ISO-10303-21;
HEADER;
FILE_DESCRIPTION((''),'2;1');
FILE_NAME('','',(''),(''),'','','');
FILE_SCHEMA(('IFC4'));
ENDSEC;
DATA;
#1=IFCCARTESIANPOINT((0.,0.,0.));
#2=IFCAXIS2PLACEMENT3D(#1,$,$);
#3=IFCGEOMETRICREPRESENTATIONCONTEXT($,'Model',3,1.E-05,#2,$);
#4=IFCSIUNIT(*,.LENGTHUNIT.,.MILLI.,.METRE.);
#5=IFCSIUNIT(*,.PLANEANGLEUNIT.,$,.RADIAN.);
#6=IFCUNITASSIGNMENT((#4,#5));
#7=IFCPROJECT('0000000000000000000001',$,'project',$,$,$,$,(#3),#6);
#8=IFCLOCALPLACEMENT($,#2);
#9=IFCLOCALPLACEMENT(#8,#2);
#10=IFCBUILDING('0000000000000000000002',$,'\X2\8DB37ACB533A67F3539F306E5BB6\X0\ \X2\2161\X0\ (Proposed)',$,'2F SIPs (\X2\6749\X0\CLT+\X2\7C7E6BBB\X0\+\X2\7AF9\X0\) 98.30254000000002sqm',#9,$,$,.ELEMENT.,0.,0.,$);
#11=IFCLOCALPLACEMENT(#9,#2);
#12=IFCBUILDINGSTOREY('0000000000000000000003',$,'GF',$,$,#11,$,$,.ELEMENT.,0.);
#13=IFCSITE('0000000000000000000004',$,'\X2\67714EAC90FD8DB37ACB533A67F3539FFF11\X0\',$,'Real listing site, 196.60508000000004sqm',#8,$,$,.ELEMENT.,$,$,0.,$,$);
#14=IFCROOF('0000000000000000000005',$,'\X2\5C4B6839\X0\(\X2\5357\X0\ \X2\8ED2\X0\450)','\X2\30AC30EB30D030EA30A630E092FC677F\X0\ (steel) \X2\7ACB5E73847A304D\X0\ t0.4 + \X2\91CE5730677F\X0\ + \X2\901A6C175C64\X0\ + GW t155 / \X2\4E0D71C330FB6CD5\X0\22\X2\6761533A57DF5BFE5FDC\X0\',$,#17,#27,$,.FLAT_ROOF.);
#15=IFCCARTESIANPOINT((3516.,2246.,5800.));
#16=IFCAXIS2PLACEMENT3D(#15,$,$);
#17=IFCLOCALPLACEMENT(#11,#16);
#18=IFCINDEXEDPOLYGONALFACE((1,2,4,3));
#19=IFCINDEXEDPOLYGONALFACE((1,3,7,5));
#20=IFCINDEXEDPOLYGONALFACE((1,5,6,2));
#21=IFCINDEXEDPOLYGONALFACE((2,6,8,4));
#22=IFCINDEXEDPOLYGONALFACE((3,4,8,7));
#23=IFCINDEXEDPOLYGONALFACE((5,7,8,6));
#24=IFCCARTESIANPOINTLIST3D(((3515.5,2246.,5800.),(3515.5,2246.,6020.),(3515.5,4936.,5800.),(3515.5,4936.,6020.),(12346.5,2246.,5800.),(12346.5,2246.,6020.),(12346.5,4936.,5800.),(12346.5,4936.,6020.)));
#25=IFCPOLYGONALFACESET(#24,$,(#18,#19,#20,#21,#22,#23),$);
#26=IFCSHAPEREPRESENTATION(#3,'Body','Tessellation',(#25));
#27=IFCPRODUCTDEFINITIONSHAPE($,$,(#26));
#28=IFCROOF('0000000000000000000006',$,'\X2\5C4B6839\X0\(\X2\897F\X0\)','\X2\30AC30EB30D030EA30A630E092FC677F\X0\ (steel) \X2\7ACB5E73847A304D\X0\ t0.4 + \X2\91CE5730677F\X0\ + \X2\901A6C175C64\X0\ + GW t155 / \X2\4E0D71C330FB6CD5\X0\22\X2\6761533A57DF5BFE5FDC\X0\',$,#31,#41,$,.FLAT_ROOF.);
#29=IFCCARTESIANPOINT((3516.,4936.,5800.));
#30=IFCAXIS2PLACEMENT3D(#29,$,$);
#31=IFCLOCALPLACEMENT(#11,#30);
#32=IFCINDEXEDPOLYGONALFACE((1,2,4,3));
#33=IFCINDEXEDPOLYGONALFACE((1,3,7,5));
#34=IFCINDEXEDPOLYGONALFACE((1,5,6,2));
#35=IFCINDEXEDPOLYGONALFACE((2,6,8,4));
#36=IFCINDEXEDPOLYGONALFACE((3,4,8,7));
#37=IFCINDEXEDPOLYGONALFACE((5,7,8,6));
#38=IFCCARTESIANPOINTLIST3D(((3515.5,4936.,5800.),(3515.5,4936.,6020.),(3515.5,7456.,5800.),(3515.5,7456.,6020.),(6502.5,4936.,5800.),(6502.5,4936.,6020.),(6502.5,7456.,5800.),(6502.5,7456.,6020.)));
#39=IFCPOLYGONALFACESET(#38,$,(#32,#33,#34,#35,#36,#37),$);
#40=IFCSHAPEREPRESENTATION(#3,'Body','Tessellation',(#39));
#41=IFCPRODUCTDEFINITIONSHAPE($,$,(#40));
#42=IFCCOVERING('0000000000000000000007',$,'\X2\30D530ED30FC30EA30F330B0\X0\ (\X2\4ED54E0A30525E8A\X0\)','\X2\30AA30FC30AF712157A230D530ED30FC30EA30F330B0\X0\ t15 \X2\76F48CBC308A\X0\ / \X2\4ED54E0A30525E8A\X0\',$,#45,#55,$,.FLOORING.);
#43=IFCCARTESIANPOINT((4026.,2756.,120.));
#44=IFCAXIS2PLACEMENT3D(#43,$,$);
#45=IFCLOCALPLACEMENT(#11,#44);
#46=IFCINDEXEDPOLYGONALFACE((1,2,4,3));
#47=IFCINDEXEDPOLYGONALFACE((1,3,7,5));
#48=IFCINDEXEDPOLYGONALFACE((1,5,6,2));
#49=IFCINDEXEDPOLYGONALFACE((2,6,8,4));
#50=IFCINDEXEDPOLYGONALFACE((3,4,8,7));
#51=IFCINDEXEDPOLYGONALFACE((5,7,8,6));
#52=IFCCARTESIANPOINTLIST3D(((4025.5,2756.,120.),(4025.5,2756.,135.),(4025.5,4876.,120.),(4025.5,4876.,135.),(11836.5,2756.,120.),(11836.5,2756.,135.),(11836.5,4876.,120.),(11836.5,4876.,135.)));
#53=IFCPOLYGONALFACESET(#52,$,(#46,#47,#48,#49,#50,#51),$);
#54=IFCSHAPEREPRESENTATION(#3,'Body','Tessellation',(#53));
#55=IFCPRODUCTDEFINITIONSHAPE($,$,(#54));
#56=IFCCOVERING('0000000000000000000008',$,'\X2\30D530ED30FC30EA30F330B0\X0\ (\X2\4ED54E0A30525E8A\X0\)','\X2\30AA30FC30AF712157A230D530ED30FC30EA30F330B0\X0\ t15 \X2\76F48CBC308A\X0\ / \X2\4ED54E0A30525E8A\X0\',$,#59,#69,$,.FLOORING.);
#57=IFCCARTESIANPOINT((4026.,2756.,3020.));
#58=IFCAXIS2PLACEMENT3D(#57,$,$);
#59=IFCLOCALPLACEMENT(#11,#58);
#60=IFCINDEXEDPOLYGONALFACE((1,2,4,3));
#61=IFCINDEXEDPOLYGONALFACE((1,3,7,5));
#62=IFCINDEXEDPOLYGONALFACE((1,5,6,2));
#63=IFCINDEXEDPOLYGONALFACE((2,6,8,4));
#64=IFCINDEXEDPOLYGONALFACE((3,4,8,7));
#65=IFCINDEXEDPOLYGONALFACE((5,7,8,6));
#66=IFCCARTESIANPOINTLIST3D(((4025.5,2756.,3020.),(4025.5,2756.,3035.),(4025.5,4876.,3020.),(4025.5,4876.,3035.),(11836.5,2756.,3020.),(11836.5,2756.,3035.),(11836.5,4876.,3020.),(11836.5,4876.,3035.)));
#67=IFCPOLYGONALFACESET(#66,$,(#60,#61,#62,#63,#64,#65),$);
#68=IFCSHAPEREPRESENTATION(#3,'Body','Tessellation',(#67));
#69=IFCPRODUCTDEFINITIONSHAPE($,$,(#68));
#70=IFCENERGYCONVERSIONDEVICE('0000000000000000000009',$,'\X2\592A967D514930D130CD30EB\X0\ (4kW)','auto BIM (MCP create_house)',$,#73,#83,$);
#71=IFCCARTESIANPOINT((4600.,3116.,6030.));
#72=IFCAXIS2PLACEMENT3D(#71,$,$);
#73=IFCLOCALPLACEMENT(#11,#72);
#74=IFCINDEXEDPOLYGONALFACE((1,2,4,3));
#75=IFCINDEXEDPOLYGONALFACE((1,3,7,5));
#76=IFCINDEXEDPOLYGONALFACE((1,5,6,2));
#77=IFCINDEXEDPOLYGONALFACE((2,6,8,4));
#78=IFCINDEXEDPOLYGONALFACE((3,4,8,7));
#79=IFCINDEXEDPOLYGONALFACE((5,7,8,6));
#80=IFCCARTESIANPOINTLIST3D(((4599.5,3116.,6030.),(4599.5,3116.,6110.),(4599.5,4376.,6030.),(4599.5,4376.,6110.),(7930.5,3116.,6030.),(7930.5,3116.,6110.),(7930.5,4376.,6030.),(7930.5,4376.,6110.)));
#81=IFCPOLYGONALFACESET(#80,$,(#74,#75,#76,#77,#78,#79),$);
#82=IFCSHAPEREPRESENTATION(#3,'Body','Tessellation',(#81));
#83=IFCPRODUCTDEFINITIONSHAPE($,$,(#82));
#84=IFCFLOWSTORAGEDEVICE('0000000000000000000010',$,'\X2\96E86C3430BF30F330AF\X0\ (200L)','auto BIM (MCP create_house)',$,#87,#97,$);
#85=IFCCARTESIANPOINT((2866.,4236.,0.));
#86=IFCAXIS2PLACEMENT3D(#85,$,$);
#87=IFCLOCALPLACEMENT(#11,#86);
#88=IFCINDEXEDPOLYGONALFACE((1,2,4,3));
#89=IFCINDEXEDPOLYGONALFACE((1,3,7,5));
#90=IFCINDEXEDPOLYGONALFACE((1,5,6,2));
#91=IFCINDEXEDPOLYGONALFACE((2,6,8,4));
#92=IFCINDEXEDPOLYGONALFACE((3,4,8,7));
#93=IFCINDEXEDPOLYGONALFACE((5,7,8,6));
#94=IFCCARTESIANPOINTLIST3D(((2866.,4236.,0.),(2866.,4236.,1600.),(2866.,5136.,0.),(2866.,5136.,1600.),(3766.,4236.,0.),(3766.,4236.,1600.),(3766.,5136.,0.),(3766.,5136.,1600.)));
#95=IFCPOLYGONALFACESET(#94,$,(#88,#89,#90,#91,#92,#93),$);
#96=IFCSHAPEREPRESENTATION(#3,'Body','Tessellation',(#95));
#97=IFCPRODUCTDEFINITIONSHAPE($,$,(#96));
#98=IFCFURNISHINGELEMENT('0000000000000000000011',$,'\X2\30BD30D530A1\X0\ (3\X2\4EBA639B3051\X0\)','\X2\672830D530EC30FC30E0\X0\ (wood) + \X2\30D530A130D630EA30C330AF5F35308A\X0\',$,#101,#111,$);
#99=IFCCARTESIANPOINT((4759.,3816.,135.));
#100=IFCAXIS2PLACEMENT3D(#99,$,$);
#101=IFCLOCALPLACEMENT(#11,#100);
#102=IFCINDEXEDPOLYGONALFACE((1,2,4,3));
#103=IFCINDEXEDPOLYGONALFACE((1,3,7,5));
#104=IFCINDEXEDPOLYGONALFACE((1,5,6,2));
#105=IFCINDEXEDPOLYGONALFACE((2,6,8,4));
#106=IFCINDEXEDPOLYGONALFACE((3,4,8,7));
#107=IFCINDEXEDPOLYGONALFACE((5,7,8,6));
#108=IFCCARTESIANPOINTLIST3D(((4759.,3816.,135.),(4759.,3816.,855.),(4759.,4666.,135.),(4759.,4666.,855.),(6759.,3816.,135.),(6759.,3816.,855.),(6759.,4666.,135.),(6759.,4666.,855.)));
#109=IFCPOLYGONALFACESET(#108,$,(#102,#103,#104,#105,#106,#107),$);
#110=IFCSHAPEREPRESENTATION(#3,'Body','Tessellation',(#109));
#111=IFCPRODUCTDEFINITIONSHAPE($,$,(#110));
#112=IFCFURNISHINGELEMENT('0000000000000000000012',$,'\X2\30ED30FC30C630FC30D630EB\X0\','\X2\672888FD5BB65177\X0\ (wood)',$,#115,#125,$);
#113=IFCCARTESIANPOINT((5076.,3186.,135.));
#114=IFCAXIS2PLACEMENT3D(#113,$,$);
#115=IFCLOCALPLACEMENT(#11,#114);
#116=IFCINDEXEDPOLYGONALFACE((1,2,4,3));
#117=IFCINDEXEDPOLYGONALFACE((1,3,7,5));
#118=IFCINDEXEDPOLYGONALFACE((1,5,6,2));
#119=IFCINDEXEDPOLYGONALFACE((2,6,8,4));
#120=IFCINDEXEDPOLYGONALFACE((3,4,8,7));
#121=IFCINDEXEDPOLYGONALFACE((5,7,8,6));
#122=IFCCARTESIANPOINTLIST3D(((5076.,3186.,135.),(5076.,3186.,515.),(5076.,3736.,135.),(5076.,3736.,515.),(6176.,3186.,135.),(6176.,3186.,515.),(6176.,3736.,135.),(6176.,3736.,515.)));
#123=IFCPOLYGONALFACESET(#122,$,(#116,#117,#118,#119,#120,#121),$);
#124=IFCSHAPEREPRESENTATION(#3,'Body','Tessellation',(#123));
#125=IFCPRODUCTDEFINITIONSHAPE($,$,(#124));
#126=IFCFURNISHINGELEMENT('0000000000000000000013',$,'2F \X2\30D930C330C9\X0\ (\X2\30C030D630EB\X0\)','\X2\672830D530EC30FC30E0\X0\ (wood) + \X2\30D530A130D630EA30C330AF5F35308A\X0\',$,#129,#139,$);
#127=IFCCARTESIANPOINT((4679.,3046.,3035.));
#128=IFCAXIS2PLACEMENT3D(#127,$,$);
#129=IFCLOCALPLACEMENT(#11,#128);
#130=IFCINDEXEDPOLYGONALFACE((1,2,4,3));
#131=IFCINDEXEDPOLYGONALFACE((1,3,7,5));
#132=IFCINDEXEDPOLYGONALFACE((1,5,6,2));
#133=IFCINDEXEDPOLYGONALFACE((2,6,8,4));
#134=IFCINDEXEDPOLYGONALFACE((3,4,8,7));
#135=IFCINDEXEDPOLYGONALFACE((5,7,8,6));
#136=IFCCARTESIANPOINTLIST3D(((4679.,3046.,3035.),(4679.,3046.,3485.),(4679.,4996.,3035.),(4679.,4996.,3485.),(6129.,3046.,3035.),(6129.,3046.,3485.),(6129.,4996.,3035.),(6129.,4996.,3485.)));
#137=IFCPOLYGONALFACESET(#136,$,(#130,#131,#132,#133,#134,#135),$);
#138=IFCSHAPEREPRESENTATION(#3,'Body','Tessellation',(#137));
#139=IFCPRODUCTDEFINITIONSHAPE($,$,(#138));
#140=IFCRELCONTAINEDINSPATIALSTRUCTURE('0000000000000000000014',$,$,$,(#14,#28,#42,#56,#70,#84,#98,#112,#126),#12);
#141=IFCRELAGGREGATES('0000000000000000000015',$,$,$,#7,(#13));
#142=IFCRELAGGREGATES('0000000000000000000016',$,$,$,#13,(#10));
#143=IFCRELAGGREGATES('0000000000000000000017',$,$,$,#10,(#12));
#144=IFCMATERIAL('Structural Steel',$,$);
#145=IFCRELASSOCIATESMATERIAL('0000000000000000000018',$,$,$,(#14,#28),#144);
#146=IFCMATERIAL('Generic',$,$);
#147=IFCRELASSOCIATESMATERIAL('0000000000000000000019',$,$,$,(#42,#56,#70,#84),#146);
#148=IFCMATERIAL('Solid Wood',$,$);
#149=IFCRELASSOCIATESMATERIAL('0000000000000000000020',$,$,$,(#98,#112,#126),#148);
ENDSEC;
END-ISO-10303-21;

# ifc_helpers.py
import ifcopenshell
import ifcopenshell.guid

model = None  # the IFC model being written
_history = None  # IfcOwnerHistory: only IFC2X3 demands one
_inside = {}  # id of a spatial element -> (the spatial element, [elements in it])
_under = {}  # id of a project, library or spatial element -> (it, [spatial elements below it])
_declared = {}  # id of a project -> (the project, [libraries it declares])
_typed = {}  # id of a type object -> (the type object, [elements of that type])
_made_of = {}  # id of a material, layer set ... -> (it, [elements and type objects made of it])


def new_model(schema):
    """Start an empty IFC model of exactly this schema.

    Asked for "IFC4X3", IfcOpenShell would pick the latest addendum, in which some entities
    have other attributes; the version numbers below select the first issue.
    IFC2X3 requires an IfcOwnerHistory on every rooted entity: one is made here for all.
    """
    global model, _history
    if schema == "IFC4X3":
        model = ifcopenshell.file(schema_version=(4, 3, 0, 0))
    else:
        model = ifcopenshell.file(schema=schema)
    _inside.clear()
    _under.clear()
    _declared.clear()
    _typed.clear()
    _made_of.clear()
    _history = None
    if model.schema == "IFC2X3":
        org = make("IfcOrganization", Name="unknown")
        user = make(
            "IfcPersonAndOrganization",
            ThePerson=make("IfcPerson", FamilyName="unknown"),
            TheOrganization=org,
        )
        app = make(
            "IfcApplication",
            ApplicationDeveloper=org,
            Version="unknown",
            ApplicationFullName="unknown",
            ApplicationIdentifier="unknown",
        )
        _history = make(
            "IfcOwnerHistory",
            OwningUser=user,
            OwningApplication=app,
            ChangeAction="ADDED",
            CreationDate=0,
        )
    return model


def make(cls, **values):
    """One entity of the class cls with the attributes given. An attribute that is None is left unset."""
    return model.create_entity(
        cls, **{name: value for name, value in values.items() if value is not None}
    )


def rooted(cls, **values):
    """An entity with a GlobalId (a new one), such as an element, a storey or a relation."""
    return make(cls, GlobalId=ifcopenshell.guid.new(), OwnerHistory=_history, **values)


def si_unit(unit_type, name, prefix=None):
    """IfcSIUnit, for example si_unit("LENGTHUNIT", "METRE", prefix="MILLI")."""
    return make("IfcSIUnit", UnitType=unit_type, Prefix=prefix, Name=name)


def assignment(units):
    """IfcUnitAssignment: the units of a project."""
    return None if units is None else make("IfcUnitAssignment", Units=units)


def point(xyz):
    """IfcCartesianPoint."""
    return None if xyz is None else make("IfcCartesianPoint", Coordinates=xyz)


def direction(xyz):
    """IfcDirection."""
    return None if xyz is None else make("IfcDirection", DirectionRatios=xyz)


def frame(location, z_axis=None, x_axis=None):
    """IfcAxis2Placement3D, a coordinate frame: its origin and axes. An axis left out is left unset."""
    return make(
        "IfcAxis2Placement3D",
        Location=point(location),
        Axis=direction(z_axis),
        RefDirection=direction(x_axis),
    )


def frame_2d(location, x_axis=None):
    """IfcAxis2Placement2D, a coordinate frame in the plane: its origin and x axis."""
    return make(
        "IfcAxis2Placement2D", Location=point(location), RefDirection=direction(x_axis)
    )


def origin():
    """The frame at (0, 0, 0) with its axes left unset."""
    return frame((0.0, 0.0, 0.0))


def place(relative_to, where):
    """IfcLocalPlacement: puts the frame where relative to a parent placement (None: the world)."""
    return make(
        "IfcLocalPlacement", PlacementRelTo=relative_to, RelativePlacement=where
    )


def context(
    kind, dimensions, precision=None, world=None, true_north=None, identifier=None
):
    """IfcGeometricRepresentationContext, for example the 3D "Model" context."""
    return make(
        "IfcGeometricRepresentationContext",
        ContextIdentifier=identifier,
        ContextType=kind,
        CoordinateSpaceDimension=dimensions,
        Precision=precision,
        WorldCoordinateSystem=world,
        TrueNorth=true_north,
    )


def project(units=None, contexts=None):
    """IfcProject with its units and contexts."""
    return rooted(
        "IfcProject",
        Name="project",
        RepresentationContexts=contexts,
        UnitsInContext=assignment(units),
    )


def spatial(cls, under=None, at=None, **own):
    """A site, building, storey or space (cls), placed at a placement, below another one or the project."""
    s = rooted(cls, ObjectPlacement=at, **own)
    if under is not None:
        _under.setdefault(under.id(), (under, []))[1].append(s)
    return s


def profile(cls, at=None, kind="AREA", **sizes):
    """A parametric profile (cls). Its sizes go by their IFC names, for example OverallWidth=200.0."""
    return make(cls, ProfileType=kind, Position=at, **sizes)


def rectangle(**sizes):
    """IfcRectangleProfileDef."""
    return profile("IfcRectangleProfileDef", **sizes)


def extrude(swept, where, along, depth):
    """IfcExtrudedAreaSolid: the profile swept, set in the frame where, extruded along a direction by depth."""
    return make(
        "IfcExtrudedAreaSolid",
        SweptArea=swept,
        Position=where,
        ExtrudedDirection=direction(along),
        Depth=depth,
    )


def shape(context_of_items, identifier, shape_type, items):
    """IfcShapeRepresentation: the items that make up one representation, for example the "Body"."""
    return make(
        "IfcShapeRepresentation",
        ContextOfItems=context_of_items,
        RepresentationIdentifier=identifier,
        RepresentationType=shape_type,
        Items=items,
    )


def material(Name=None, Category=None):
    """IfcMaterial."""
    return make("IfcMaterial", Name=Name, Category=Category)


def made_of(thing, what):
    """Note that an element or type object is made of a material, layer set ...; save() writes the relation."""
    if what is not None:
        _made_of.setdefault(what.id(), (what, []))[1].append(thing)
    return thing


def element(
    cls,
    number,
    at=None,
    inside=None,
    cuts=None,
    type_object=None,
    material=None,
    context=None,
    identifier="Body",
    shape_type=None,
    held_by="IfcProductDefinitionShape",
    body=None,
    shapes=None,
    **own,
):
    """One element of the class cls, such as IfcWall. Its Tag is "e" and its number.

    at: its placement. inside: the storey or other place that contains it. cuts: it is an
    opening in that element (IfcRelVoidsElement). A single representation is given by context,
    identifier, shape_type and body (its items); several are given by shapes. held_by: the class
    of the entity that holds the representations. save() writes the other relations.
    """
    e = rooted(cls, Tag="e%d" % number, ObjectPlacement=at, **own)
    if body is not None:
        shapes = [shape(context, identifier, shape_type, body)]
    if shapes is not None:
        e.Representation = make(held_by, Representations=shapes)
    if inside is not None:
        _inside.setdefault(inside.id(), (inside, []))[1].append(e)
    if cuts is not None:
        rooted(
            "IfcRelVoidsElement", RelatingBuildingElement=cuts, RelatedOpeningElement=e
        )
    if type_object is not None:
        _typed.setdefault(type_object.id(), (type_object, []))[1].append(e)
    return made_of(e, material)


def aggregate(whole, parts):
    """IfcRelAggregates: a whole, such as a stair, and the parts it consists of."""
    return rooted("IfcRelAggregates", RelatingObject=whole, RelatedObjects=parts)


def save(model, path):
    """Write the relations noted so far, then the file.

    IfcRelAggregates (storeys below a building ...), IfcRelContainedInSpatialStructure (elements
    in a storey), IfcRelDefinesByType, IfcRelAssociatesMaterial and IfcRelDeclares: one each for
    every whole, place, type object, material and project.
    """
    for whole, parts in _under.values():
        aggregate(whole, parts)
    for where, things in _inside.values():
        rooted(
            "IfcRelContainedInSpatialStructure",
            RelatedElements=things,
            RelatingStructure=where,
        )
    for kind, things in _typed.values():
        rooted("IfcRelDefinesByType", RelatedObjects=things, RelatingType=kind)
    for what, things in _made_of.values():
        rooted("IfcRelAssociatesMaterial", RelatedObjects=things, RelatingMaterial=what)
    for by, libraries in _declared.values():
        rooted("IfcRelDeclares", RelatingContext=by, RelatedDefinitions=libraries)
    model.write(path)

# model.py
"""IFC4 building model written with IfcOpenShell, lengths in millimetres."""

from ifc_helpers import new_model, si_unit, frame, frame_2d, origin, place, context, project, spatial, rectangle, extrude, material, element, save


model = new_model("IFC4")

# Units and contexts
model_context = context("Model", 3, precision=1e-05, world=origin())
ifc_project = project(units=[si_unit("LENGTHUNIT", "METRE", prefix="MILLI"), si_unit("PLANEANGLEUNIT", "RADIAN")], contexts=[model_context])

# Site, building, storey
site_placement = place(None, origin())
site = spatial("IfcSite", under=ifc_project, at=site_placement, Name="東京都足立区柳原１", ObjectType="Real listing site, 196.60508000000004sqm", CompositionType="ELEMENT", RefElevation=0.0)
building_placement = place(site_placement, origin())
building = spatial("IfcBuilding", under=site, at=building_placement, Name="足立区柳原の家 Ⅱ (Proposed)", ObjectType="2F SIPs (杉CLT+籾殻+竹) 98.30254000000002sqm", CompositionType="ELEMENT", ElevationOfRefHeight=0.0, ElevationOfTerrain=0.0)
storey_placement = place(building_placement, origin())
storey = spatial("IfcBuildingStorey", under=building, at=storey_placement, Name="GF", CompositionType="ELEMENT", Elevation=0.0)

# Shared definitions
ifc_material_1 = material(Name="Solid Wood")

# Roofs
ifc_material_2 = material(Name="Structural Steel")
roof_1_placement = place(storey_placement, frame((3516.0, 2246.0, 5800.0)))
element("IfcRoof", 1, at=roof_1_placement, inside=storey, material=ifc_material_2, Name="屋根(南 軒450)", Description="ガルバリウム鋼板 (steel) 立平葺き t0.4 + 野地板 + 通気層 + GW t155 / 不燃・法22条区域対応", PredefinedType="FLAT_ROOF", context=model_context, shape_type="SweptSolid", body=[
    extrude(rectangle(XDim=8831.0, YDim=2690.0, at=frame_2d((4415.0, 1345.0))), frame((3516.0, 2246.0, 5800.0)), (0.0, 0.0, 1.0), 220.0),
])
roof_2_placement = place(storey_placement, frame((3516.0, 4936.0, 5800.0)))
element("IfcRoof", 2, at=roof_2_placement, inside=storey, material=ifc_material_2, Name="屋根(西)", Description="ガルバリウム鋼板 (steel) 立平葺き t0.4 + 野地板 + 通気層 + GW t155 / 不燃・法22条区域対応", PredefinedType="FLAT_ROOF", context=model_context, shape_type="SweptSolid", body=[
    extrude(rectangle(XDim=2987.0, YDim=2520.0, at=frame_2d((1493.0, 1260.0))), frame((3516.0, 4936.0, 5800.0)), (0.0, 0.0, 1.0), 220.0),
])

# Coverings
ifc_material_3 = material(Name="Generic")
covering_1_placement = place(storey_placement, frame((4026.0, 2756.0, 120.0)))
element("IfcCovering", 3, at=covering_1_placement, inside=storey, material=ifc_material_3, Name="フローリング (仕上げ床)", Description="オーク無垢フローリング t15 直貼り / 仕上げ床", PredefinedType="FLOORING", context=model_context, shape_type="SweptSolid", body=[
    extrude(rectangle(XDim=7811.0, YDim=2120.0, at=frame_2d((3905.0, 1060.0))), frame((4026.0, 2756.0, 120.0)), (0.0, 0.0, 1.0), 15.0),
])
covering_2_placement = place(storey_placement, frame((4026.0, 2756.0, 3020.0)))
element("IfcCovering", 4, at=covering_2_placement, inside=storey, material=ifc_material_3, Name="フローリング (仕上げ床)", Description="オーク無垢フローリング t15 直貼り / 仕上げ床", PredefinedType="FLOORING", context=model_context, shape_type="SweptSolid", body=[
    extrude(rectangle(XDim=7811.0, YDim=2120.0, at=frame_2d((3905.0, 1060.0))), frame((4026.0, 2756.0, 3020.0)), (0.0, 0.0, 1.0), 15.0),
])

# Energy conversion device
energy_conversion_device_placement = place(storey_placement, frame((4600.0, 3116.0, 6030.0)))
element("IfcEnergyConversionDevice", 5, at=energy_conversion_device_placement, inside=storey, material=ifc_material_3, Name="太陽光パネル (4kW)", Description="auto BIM (MCP create_house)", context=model_context, shape_type="SweptSolid", body=[
    extrude(rectangle(XDim=3331.0, YDim=1260.0, at=frame_2d((1665.0, 630.0))), frame((4600.0, 3116.0, 6030.0)), (0.0, 0.0, 1.0), 80.0),
])

# Flow storage device
flow_storage_device_placement = place(storey_placement, frame((2866.0, 4236.0, 0.0)))
element("IfcFlowStorageDevice", 6, at=flow_storage_device_placement, inside=storey, material=ifc_material_3, Name="雨水タンク (200L)", Description="auto BIM (MCP create_house)", context=model_context, shape_type="SweptSolid", body=[
    extrude(rectangle(XDim=900.0, YDim=900.0, at=frame_2d((450.0, 450.0))), frame((2866.0, 4236.0, 0.0)), (0.0, 0.0, 1.0), 1600.0),
])

# Furnishing elements
furnishing_1_placement = place(storey_placement, frame((4759.0, 3816.0, 135.0)))
element("IfcFurnishingElement", 7, at=furnishing_1_placement, inside=storey, material=ifc_material_1, Name="ソファ (3人掛け)", Description="木フレーム (wood) + ファブリック張り", context=model_context, shape_type="SweptSolid", body=[
    extrude(rectangle(XDim=2000.0, YDim=850.0, at=frame_2d((1000.0, 425.0))), frame((4759.0, 3816.0, 135.0)), (0.0, 0.0, 1.0), 720.0),
])
furnishing_2_placement = place(storey_placement, frame((5076.0, 3186.0, 135.0)))
element("IfcFurnishingElement", 8, at=furnishing_2_placement, inside=storey, material=ifc_material_1, Name="ローテーブル", Description="木製家具 (wood)", context=model_context, shape_type="SweptSolid", body=[
    extrude(rectangle(XDim=1100.0, YDim=550.0, at=frame_2d((550.0, 275.0))), frame((5076.0, 3186.0, 135.0)), (0.0, 0.0, 1.0), 380.0),
])
furnishing_3_placement = place(storey_placement, frame((4679.0, 3046.0, 3035.0)))
element("IfcFurnishingElement", 9, at=furnishing_3_placement, inside=storey, material=ifc_material_1, Name="2F ベッド (ダブル)", Description="木フレーム (wood) + ファブリック張り", context=model_context, shape_type="SweptSolid", body=[
    extrude(rectangle(XDim=1450.0, YDim=1950.0, at=frame_2d((725.0, 975.0))), frame((4679.0, 3046.0, 3035.0)), (0.0, 0.0, 1.0), 450.0),
])

save(model, "model.ifc")
